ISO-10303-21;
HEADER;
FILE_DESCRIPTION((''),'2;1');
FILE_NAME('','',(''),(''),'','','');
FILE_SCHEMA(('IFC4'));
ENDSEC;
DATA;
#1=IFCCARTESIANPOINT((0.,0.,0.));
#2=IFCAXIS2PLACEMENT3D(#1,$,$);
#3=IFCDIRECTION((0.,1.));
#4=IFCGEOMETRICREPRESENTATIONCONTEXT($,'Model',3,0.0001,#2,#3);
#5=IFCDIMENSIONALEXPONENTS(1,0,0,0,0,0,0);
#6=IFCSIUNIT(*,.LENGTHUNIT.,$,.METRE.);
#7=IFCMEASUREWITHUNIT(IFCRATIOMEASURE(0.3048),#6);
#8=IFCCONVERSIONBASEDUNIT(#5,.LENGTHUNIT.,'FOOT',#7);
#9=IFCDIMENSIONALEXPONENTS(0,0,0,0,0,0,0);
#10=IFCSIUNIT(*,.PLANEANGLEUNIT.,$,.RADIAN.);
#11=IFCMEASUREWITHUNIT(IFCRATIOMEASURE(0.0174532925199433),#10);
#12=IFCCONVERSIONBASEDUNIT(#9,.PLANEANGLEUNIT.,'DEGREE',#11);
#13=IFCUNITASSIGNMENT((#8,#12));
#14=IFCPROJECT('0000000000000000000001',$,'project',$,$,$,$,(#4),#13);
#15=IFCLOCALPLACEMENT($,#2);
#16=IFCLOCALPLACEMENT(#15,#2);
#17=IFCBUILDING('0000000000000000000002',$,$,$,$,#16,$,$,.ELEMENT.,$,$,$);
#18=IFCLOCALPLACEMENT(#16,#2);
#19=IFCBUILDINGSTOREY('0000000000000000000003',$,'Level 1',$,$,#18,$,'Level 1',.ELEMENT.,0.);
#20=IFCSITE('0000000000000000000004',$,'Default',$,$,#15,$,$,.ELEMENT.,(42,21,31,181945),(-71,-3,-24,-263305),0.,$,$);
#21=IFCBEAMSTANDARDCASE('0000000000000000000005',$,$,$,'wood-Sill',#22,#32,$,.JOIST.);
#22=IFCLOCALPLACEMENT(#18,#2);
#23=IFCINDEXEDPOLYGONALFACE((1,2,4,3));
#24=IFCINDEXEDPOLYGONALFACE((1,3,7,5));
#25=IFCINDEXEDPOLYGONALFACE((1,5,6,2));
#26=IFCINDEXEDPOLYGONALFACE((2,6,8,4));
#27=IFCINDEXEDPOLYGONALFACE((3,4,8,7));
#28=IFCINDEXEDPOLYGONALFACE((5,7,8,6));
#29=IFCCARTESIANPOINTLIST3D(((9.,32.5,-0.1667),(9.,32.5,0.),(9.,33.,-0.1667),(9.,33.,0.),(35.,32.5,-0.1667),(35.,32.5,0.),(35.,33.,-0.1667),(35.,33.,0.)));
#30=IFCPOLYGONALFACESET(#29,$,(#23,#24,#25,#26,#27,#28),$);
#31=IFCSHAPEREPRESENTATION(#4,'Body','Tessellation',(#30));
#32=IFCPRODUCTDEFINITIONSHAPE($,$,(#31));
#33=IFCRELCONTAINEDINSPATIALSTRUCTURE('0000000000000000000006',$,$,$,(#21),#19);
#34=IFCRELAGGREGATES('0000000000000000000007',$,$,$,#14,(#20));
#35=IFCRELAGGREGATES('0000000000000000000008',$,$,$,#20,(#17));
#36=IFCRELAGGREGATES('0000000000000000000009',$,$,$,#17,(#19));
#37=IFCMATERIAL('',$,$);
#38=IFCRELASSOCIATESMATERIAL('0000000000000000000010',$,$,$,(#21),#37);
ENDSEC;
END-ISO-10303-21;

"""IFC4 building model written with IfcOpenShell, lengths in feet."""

from ifc_helpers import new_model, entity, si_unit, converted_unit, direction, frame, origin, place, context, project, spatial, rectangle, extrude, material, element, save


model = new_model("IFC4")

# Units and contexts
model_context = context("Model", 3, precision=0.0001, world=origin(), true_north=direction((0.0, 1.0)))
ifc_project = project(units=[converted_unit("LENGTHUNIT", "FOOT", entity("IfcRatioMeasure", 0.3048), si_unit("LENGTHUNIT", "METRE"), dimensions=[1, 0, 0, 0, 0, 0, 0]), converted_unit("PLANEANGLEUNIT", "DEGREE", entity("IfcRatioMeasure", 0.0174532925199433), si_unit("PLANEANGLEUNIT", "RADIAN"), dimensions=[0, 0, 0, 0, 0, 0, 0])], contexts=[model_context])

# Site, building, storey
site_placement = place(None, origin())
site = spatial("IfcSite", under=ifc_project, at=site_placement, Name="Default", CompositionType="ELEMENT", RefLatitude=(42, 21, 31, 181945), RefLongitude=(-71, -3, -24, -263305), RefElevation=0.0)
building_placement = place(site_placement, origin())
building = spatial("IfcBuilding", under=site, at=building_placement, CompositionType="ELEMENT")
storey_placement = place(building_placement, origin())
storey = spatial("IfcBuildingStorey", under=building, at=storey_placement, Name="Level 1", LongName="Level 1", CompositionType="ELEMENT", Elevation=0.0)

# Shared definitions
placement = place(storey_placement, frame((22.0, 45.75, 0.0), z_axis=(0.0, 0.0, 1.0), x_axis=(0.0, -1.0, 0.0)))

# Beam
ifc_material_1 = material(Name="")
beam_1_placement = place(placement, frame((13.0, 0.0, -0.1667), z_axis=(0.0, 0.0, 1.0), x_axis=(0.0, -1.0, 0.0)))
element("IfcBeamStandardCase", 1, at=beam_1_placement, inside=storey, material=ifc_material_1, ObjectType="wood-Sill", PredefinedType="JOIST", context=model_context, shape_type="SweptSolid", body=[
    extrude(rectangle(XDim=26.0, YDim=0.5), origin(), (0.0, 0.0, 1.0), 0.1667),
])

save(model, "model.ifc")
